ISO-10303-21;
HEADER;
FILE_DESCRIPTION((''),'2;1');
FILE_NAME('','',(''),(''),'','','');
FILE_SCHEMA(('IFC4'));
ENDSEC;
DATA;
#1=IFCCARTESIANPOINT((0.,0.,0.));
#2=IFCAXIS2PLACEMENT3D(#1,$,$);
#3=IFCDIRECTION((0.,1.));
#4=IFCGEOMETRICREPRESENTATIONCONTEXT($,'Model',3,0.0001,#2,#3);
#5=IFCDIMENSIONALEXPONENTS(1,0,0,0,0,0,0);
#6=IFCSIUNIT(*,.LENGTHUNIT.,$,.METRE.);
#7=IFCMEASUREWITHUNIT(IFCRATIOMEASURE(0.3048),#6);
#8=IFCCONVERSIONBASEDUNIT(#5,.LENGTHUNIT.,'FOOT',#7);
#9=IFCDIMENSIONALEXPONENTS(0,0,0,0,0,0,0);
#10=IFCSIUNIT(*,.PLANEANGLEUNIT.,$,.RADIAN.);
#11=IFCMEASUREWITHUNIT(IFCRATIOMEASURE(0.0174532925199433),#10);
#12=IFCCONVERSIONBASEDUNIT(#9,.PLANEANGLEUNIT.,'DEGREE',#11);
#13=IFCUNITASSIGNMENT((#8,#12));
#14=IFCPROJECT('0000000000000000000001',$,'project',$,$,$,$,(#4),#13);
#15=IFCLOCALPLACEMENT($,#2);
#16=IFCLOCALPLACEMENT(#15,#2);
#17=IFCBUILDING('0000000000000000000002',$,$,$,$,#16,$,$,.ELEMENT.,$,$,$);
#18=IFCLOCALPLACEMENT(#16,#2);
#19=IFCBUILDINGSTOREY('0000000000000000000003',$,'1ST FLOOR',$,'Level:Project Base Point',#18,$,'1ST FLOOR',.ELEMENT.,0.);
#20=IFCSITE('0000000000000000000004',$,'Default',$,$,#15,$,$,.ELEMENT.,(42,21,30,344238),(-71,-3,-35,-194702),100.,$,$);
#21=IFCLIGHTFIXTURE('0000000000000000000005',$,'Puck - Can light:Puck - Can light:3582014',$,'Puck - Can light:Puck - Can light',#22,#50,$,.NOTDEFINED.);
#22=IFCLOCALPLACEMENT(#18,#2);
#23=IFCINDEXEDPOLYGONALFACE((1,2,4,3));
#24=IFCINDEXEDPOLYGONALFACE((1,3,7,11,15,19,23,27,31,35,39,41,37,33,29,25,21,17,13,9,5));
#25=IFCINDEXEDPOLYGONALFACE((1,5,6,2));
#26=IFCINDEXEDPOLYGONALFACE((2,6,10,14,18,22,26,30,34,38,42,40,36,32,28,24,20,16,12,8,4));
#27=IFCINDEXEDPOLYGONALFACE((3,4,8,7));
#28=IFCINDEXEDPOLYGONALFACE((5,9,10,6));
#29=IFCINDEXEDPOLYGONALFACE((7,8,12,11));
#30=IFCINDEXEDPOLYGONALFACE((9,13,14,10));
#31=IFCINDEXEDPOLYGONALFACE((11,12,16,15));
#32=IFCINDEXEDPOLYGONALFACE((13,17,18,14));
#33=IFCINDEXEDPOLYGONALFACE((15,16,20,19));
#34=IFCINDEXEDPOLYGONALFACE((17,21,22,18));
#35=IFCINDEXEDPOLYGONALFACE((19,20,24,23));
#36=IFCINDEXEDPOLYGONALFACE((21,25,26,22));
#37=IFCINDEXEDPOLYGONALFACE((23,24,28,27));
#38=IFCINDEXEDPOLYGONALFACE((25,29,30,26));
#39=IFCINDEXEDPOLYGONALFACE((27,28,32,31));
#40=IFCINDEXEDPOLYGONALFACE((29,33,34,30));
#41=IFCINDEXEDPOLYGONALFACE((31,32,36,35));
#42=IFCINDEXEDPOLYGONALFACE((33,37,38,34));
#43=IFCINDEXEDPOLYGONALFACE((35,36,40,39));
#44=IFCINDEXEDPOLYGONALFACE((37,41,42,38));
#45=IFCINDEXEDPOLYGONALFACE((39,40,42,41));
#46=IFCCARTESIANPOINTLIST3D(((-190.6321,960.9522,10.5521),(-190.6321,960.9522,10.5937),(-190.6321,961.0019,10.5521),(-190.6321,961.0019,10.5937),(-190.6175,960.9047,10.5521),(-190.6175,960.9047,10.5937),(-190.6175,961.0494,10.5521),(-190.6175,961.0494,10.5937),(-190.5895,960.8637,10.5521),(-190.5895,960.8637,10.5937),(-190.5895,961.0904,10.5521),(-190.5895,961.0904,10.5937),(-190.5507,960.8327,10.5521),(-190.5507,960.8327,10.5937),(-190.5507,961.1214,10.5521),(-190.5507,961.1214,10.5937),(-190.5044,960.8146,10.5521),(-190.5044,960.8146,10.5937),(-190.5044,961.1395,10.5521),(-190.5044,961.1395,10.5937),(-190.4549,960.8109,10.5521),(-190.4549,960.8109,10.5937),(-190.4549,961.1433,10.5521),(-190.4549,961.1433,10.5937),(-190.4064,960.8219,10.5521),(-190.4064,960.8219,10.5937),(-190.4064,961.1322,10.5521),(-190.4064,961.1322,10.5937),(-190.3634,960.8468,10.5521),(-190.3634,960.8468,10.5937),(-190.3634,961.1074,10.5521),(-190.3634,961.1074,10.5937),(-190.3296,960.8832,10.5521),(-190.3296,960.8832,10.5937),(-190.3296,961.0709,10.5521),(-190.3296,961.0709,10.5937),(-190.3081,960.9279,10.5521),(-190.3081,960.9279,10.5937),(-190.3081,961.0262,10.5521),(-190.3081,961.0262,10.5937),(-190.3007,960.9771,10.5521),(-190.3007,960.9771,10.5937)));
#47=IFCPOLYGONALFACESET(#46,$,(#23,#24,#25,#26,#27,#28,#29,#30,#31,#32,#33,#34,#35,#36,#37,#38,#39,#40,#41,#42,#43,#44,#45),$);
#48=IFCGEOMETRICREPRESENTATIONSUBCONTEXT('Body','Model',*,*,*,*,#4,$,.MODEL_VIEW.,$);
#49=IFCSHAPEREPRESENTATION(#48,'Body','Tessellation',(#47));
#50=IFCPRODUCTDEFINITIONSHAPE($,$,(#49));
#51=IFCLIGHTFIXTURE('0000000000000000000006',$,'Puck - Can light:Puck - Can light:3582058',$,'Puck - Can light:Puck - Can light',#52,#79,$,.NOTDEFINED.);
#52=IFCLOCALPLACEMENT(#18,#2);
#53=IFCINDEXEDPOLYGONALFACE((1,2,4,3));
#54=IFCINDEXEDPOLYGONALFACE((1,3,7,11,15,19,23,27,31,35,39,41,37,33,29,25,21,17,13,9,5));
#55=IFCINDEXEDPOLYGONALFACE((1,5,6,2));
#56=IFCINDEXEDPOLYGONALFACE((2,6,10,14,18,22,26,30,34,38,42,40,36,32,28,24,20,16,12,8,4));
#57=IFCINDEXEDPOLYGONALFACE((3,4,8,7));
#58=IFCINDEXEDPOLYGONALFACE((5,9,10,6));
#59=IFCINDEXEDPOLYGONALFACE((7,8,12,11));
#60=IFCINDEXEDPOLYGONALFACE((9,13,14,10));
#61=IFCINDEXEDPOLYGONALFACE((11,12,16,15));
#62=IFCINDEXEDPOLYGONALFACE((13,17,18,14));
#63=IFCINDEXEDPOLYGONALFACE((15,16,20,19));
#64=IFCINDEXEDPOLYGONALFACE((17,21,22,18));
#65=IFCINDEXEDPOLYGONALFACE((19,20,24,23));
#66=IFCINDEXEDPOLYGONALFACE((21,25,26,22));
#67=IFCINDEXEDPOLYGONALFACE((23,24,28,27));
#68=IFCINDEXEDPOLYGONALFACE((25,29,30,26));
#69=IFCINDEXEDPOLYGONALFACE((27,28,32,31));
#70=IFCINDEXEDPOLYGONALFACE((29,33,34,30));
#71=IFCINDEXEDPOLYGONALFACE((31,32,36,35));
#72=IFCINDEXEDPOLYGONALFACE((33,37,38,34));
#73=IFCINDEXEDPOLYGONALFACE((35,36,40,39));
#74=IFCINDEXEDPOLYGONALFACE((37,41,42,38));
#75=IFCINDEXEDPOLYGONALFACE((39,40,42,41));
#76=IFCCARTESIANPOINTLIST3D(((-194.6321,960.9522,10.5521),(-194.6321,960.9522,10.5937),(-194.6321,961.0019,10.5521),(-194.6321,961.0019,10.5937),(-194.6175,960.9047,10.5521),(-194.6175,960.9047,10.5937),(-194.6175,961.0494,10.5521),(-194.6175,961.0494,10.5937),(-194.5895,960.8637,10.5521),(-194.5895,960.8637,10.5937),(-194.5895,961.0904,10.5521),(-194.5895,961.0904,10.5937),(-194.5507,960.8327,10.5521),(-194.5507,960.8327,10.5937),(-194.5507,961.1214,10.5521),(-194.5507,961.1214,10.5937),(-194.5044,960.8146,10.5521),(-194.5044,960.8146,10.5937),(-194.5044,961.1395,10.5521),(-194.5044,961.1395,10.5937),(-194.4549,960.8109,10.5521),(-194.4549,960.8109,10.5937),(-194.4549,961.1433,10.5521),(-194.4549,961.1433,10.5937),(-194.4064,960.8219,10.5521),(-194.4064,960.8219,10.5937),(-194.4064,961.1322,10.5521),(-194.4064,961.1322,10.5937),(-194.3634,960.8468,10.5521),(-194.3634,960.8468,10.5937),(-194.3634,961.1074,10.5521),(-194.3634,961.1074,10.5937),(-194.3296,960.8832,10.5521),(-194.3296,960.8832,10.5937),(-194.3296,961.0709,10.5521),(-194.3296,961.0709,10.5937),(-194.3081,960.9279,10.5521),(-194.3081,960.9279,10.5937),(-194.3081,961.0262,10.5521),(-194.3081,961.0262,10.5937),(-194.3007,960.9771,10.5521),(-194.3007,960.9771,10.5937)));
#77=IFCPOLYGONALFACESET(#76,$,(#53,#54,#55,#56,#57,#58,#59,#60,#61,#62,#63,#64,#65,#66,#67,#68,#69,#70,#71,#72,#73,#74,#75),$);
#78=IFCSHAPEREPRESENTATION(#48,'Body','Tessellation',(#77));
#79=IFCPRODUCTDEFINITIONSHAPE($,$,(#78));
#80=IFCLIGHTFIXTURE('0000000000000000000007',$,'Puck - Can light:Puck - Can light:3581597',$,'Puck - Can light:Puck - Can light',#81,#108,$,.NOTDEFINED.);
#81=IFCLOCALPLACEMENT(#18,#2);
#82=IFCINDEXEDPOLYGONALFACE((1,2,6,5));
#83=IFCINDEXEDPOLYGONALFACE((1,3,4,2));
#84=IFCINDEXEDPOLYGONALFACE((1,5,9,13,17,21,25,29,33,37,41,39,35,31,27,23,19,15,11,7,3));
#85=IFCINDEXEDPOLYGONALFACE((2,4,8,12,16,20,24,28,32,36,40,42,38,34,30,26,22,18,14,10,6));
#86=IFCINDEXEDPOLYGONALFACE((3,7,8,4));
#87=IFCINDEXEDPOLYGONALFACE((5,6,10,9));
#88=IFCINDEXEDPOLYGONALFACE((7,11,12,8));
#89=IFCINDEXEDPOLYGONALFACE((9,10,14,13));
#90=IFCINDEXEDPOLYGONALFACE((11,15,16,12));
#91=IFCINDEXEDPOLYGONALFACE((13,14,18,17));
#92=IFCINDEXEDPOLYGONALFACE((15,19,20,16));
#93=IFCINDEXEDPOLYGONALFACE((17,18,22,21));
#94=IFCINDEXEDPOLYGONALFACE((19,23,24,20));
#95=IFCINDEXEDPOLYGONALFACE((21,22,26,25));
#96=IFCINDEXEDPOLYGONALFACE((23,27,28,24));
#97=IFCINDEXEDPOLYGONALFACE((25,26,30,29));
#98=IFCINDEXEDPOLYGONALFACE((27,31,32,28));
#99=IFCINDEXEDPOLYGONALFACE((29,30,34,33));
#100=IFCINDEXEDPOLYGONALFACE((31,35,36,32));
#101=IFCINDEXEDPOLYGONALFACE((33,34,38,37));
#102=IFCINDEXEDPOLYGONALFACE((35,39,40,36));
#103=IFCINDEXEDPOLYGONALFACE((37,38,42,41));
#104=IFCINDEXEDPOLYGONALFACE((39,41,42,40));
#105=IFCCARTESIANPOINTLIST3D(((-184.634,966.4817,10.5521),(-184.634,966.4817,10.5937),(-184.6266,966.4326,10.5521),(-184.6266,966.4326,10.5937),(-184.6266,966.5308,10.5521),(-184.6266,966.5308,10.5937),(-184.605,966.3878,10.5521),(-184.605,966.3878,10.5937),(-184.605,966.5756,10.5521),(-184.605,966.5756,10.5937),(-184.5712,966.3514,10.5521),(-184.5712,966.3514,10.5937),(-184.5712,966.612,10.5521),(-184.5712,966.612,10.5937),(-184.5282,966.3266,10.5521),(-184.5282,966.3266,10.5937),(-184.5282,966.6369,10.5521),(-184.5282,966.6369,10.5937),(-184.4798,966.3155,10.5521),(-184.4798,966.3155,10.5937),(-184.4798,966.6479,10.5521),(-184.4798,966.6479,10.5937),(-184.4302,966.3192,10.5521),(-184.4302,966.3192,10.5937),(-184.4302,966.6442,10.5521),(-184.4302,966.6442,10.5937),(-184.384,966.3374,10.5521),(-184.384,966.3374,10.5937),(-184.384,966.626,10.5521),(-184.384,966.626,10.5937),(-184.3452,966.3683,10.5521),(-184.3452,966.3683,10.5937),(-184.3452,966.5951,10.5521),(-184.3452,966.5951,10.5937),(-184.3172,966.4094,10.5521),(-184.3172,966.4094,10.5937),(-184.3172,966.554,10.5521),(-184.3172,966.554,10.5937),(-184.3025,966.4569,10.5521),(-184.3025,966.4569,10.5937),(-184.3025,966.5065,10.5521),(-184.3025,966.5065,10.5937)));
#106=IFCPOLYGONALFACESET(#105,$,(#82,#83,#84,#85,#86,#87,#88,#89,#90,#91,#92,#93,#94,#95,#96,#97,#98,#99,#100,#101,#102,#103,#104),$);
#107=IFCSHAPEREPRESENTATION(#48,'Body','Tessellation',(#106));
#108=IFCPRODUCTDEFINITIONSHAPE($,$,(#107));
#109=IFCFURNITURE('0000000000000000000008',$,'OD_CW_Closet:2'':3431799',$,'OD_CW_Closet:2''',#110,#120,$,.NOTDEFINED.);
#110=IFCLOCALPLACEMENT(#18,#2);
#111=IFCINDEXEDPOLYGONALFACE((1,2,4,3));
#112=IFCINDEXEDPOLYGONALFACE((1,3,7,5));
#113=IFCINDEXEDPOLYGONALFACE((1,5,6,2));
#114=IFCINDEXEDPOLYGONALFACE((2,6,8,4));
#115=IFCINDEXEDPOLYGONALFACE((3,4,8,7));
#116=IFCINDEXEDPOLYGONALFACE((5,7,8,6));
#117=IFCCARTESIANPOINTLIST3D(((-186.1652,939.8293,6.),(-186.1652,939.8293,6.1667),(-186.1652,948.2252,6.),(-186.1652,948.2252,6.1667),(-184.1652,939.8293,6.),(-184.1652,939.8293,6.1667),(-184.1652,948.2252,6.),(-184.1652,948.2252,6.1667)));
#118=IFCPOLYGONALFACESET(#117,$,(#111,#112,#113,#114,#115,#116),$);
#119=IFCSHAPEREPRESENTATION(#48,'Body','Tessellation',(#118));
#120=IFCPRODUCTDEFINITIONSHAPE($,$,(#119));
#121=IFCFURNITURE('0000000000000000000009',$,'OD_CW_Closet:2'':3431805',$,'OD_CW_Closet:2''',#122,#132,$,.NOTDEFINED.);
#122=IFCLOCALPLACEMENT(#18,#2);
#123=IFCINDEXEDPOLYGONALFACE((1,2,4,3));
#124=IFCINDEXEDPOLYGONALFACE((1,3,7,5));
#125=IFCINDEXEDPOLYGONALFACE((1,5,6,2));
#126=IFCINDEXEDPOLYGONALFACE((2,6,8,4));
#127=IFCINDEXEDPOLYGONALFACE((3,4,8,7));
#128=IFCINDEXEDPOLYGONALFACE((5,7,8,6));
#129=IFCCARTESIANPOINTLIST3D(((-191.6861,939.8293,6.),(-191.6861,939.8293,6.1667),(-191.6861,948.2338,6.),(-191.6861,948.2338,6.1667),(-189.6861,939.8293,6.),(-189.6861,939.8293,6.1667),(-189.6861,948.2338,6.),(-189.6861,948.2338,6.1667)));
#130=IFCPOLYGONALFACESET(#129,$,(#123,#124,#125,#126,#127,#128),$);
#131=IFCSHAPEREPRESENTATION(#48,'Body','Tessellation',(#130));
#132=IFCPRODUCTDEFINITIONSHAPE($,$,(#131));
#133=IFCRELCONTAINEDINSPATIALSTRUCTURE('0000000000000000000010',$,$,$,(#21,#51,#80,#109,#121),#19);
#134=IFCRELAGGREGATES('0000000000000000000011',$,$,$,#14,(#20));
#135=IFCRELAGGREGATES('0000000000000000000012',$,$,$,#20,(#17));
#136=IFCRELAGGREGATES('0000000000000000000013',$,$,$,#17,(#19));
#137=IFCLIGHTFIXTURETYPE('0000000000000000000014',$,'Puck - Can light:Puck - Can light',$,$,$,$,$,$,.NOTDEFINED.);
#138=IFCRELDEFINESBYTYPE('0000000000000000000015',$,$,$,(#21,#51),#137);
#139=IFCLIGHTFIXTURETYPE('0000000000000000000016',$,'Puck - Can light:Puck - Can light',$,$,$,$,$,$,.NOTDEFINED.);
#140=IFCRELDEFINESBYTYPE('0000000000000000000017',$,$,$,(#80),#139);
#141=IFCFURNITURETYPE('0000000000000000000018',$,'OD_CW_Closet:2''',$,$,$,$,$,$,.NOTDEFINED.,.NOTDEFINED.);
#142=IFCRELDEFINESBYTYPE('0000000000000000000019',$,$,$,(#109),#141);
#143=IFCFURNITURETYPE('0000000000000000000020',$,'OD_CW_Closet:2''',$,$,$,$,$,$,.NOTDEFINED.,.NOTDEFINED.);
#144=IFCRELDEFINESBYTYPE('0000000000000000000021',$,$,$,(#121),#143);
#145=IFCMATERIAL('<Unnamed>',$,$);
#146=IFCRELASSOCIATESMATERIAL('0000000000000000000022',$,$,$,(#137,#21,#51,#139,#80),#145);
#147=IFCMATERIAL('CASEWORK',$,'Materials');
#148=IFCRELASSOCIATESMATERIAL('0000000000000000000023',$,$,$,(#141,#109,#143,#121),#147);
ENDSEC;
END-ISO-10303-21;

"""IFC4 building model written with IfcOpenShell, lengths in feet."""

from ifc_helpers import new_model, entity, si_unit, converted_unit, direction, frame, frame_2d, origin, place, context, subcontext, project, spatial, rectangle, circle, extrude, source, transform, mapped, material, type_object, type_shapes, element, save


model = new_model("IFC4")

# Units and contexts
model_context = context("Model", 3, precision=0.0001, world=origin(), true_north=direction((0.0, 1.0)))
body_context = subcontext(model_context, "Body", "Model", "MODEL_VIEW")
ifc_project = project(units=[converted_unit("LENGTHUNIT", "FOOT", entity("IfcRatioMeasure", 0.3048), si_unit("LENGTHUNIT", "METRE"), dimensions=[1, 0, 0, 0, 0, 0, 0]), converted_unit("PLANEANGLEUNIT", "DEGREE", entity("IfcRatioMeasure", 0.0174532925199433), si_unit("PLANEANGLEUNIT", "RADIAN"), dimensions=[0, 0, 0, 0, 0, 0, 0])], contexts=[model_context])

# Site, building, storey
site_placement = place(None, origin())
site = spatial("IfcSite", under=ifc_project, at=site_placement, Name="Default", CompositionType="ELEMENT", RefLatitude=(42, 21, 30, 344238), RefLongitude=(-71, -3, -35, -194702), RefElevation=100.0)
building_placement = place(site_placement, origin())
building = spatial("IfcBuilding", under=site, at=building_placement, CompositionType="ELEMENT")
storey_placement = place(building_placement, origin())
storey = spatial("IfcBuildingStorey", under=building, at=storey_placement, Name="1ST FLOOR", ObjectType="Level:Project Base Point", LongName="1ST FLOOR", CompositionType="ELEMENT", Elevation=0.0)

# Light fixtures
ifc_material_1 = material(Name="<Unnamed>")
light_fixture_type_1 = type_object("IfcLightFixtureType", Name="Puck - Can light:Puck - Can light", PredefinedType="NOTDEFINED", material=ifc_material_1)
shared_shape_1 = source(origin(), body_context, "Body", "SweptSolid", [
    extrude(circle(Radius=0.1667, at=frame_2d((0.0, 0.0), x_axis=(1.0, 0.0))), frame((0.0, 0.0, -0.0417)), (0.0, 0.0, 1.0), 0.0417),
])
type_shapes(light_fixture_type_1, [shared_shape_1])
for number, where, z_axis, x_axis, name in (
    (1, (-190.4673, 960.9771, 10.5521), (0.0, 0.0, -1.0), (1.0, 0.0, 0.0), "Puck - Can light:Puck - Can light:3582014"),
    (2, (-194.4673, 960.9771, 10.5521), (0.0, 0.0, -1.0), (1.0, 0.0, 0.0), "Puck - Can light:Puck - Can light:3582058"),
):
    element("IfcLightFixture", number, at=place(storey_placement, frame(where, z_axis=z_axis, x_axis=x_axis)), inside=storey, type_object=light_fixture_type_1, material=ifc_material_1, Name=name, ObjectType="Puck - Can light:Puck - Can light", PredefinedType="NOTDEFINED", context=body_context, shape_type="MappedRepresentation", body=[
        mapped(shared_shape_1, transform((0.0, 0.0, 0.0), scale=1.0)),
    ])
light_fixture_type_2 = type_object("IfcLightFixtureType", Name="Puck - Can light:Puck - Can light", PredefinedType="NOTDEFINED", material=ifc_material_1)
shared_shape_2 = source(origin(), body_context, "Body", "SweptSolid", [
    extrude(circle(Radius=0.1667, at=frame_2d((0.0, 0.0), x_axis=(1.0, 0.0))), frame((0.0, 0.0, -0.0417)), (0.0, 0.0, 1.0), 0.0417),
])
type_shapes(light_fixture_type_2, [shared_shape_2])
light_fixture_placement = place(storey_placement, frame((-184.4673, 966.4817, 10.5521), z_axis=(0.0, 0.0, -1.0), x_axis=(-1.0, 0.0, 0.0)))
element("IfcLightFixture", 3, at=light_fixture_placement, inside=storey, type_object=light_fixture_type_2, material=ifc_material_1, Name="Puck - Can light:Puck - Can light:3581597", ObjectType="Puck - Can light:Puck - Can light", PredefinedType="NOTDEFINED", context=body_context, shape_type="MappedRepresentation", body=[
    mapped(shared_shape_2, transform((0.0, 0.0, 0.0), scale=1.0)),
])

# Furniture
ifc_material_2 = material(Name="CASEWORK", Category="Materials")
furniture_type_1 = type_object("IfcFurnitureType", Name="OD_CW_Closet:2'", AssemblyPlace="NOTDEFINED", PredefinedType="NOTDEFINED", material=ifc_material_2)
shared_shape_3 = source(origin(), body_context, "Body", "SweptSolid", [
    extrude(rectangle(XDim=2.0, YDim=8.3958, at=frame_2d((0.0, 0.0), x_axis=(1.0, 0.0))), frame((4.1979, 1.0, 0.0), z_axis=(0.0, 0.0, 1.0), x_axis=(0.0, -1.0, 0.0)), (0.0, 0.0, 1.0), 0.1667),
])
type_shapes(furniture_type_1, [shared_shape_3])
furniture_1_placement = place(storey_placement, frame((-186.1652, 948.2252, 6.0), z_axis=(0.0, 0.0, 1.0), x_axis=(0.0, -1.0, 0.0)))
element("IfcFurniture", 4, at=furniture_1_placement, inside=storey, type_object=furniture_type_1, material=ifc_material_2, Name="OD_CW_Closet:2':3431799", ObjectType="OD_CW_Closet:2'", PredefinedType="NOTDEFINED", context=body_context, shape_type="MappedRepresentation", body=[
    mapped(shared_shape_3, transform((0.0, 0.0, 0.0), scale=1.0)),
])
furniture_type_2 = type_object("IfcFurnitureType", Name="OD_CW_Closet:2'", AssemblyPlace="NOTDEFINED", PredefinedType="NOTDEFINED", material=ifc_material_2)
shared_shape_4 = source(origin(), body_context, "Body", "SweptSolid", [
    extrude(rectangle(XDim=8.4045, YDim=2.0, at=frame_2d((0.0, 0.0), x_axis=(1.0, 0.0))), frame((4.2022, 1.0, 0.0)), (0.0, 0.0, 1.0), 0.1667),
])
type_shapes(furniture_type_2, [shared_shape_4])
furniture_2_placement = place(storey_placement, frame((-191.6861, 948.2338, 6.0), z_axis=(0.0, 0.0, 1.0), x_axis=(0.0, -1.0, 0.0)))
element("IfcFurniture", 5, at=furniture_2_placement, inside=storey, type_object=furniture_type_2, material=ifc_material_2, Name="OD_CW_Closet:2':3431805", ObjectType="OD_CW_Closet:2'", PredefinedType="NOTDEFINED", context=body_context, shape_type="MappedRepresentation", body=[
    mapped(shared_shape_4, transform((0.0, 0.0, 0.0), scale=1.0)),
])

save(model, "model.ifc")
